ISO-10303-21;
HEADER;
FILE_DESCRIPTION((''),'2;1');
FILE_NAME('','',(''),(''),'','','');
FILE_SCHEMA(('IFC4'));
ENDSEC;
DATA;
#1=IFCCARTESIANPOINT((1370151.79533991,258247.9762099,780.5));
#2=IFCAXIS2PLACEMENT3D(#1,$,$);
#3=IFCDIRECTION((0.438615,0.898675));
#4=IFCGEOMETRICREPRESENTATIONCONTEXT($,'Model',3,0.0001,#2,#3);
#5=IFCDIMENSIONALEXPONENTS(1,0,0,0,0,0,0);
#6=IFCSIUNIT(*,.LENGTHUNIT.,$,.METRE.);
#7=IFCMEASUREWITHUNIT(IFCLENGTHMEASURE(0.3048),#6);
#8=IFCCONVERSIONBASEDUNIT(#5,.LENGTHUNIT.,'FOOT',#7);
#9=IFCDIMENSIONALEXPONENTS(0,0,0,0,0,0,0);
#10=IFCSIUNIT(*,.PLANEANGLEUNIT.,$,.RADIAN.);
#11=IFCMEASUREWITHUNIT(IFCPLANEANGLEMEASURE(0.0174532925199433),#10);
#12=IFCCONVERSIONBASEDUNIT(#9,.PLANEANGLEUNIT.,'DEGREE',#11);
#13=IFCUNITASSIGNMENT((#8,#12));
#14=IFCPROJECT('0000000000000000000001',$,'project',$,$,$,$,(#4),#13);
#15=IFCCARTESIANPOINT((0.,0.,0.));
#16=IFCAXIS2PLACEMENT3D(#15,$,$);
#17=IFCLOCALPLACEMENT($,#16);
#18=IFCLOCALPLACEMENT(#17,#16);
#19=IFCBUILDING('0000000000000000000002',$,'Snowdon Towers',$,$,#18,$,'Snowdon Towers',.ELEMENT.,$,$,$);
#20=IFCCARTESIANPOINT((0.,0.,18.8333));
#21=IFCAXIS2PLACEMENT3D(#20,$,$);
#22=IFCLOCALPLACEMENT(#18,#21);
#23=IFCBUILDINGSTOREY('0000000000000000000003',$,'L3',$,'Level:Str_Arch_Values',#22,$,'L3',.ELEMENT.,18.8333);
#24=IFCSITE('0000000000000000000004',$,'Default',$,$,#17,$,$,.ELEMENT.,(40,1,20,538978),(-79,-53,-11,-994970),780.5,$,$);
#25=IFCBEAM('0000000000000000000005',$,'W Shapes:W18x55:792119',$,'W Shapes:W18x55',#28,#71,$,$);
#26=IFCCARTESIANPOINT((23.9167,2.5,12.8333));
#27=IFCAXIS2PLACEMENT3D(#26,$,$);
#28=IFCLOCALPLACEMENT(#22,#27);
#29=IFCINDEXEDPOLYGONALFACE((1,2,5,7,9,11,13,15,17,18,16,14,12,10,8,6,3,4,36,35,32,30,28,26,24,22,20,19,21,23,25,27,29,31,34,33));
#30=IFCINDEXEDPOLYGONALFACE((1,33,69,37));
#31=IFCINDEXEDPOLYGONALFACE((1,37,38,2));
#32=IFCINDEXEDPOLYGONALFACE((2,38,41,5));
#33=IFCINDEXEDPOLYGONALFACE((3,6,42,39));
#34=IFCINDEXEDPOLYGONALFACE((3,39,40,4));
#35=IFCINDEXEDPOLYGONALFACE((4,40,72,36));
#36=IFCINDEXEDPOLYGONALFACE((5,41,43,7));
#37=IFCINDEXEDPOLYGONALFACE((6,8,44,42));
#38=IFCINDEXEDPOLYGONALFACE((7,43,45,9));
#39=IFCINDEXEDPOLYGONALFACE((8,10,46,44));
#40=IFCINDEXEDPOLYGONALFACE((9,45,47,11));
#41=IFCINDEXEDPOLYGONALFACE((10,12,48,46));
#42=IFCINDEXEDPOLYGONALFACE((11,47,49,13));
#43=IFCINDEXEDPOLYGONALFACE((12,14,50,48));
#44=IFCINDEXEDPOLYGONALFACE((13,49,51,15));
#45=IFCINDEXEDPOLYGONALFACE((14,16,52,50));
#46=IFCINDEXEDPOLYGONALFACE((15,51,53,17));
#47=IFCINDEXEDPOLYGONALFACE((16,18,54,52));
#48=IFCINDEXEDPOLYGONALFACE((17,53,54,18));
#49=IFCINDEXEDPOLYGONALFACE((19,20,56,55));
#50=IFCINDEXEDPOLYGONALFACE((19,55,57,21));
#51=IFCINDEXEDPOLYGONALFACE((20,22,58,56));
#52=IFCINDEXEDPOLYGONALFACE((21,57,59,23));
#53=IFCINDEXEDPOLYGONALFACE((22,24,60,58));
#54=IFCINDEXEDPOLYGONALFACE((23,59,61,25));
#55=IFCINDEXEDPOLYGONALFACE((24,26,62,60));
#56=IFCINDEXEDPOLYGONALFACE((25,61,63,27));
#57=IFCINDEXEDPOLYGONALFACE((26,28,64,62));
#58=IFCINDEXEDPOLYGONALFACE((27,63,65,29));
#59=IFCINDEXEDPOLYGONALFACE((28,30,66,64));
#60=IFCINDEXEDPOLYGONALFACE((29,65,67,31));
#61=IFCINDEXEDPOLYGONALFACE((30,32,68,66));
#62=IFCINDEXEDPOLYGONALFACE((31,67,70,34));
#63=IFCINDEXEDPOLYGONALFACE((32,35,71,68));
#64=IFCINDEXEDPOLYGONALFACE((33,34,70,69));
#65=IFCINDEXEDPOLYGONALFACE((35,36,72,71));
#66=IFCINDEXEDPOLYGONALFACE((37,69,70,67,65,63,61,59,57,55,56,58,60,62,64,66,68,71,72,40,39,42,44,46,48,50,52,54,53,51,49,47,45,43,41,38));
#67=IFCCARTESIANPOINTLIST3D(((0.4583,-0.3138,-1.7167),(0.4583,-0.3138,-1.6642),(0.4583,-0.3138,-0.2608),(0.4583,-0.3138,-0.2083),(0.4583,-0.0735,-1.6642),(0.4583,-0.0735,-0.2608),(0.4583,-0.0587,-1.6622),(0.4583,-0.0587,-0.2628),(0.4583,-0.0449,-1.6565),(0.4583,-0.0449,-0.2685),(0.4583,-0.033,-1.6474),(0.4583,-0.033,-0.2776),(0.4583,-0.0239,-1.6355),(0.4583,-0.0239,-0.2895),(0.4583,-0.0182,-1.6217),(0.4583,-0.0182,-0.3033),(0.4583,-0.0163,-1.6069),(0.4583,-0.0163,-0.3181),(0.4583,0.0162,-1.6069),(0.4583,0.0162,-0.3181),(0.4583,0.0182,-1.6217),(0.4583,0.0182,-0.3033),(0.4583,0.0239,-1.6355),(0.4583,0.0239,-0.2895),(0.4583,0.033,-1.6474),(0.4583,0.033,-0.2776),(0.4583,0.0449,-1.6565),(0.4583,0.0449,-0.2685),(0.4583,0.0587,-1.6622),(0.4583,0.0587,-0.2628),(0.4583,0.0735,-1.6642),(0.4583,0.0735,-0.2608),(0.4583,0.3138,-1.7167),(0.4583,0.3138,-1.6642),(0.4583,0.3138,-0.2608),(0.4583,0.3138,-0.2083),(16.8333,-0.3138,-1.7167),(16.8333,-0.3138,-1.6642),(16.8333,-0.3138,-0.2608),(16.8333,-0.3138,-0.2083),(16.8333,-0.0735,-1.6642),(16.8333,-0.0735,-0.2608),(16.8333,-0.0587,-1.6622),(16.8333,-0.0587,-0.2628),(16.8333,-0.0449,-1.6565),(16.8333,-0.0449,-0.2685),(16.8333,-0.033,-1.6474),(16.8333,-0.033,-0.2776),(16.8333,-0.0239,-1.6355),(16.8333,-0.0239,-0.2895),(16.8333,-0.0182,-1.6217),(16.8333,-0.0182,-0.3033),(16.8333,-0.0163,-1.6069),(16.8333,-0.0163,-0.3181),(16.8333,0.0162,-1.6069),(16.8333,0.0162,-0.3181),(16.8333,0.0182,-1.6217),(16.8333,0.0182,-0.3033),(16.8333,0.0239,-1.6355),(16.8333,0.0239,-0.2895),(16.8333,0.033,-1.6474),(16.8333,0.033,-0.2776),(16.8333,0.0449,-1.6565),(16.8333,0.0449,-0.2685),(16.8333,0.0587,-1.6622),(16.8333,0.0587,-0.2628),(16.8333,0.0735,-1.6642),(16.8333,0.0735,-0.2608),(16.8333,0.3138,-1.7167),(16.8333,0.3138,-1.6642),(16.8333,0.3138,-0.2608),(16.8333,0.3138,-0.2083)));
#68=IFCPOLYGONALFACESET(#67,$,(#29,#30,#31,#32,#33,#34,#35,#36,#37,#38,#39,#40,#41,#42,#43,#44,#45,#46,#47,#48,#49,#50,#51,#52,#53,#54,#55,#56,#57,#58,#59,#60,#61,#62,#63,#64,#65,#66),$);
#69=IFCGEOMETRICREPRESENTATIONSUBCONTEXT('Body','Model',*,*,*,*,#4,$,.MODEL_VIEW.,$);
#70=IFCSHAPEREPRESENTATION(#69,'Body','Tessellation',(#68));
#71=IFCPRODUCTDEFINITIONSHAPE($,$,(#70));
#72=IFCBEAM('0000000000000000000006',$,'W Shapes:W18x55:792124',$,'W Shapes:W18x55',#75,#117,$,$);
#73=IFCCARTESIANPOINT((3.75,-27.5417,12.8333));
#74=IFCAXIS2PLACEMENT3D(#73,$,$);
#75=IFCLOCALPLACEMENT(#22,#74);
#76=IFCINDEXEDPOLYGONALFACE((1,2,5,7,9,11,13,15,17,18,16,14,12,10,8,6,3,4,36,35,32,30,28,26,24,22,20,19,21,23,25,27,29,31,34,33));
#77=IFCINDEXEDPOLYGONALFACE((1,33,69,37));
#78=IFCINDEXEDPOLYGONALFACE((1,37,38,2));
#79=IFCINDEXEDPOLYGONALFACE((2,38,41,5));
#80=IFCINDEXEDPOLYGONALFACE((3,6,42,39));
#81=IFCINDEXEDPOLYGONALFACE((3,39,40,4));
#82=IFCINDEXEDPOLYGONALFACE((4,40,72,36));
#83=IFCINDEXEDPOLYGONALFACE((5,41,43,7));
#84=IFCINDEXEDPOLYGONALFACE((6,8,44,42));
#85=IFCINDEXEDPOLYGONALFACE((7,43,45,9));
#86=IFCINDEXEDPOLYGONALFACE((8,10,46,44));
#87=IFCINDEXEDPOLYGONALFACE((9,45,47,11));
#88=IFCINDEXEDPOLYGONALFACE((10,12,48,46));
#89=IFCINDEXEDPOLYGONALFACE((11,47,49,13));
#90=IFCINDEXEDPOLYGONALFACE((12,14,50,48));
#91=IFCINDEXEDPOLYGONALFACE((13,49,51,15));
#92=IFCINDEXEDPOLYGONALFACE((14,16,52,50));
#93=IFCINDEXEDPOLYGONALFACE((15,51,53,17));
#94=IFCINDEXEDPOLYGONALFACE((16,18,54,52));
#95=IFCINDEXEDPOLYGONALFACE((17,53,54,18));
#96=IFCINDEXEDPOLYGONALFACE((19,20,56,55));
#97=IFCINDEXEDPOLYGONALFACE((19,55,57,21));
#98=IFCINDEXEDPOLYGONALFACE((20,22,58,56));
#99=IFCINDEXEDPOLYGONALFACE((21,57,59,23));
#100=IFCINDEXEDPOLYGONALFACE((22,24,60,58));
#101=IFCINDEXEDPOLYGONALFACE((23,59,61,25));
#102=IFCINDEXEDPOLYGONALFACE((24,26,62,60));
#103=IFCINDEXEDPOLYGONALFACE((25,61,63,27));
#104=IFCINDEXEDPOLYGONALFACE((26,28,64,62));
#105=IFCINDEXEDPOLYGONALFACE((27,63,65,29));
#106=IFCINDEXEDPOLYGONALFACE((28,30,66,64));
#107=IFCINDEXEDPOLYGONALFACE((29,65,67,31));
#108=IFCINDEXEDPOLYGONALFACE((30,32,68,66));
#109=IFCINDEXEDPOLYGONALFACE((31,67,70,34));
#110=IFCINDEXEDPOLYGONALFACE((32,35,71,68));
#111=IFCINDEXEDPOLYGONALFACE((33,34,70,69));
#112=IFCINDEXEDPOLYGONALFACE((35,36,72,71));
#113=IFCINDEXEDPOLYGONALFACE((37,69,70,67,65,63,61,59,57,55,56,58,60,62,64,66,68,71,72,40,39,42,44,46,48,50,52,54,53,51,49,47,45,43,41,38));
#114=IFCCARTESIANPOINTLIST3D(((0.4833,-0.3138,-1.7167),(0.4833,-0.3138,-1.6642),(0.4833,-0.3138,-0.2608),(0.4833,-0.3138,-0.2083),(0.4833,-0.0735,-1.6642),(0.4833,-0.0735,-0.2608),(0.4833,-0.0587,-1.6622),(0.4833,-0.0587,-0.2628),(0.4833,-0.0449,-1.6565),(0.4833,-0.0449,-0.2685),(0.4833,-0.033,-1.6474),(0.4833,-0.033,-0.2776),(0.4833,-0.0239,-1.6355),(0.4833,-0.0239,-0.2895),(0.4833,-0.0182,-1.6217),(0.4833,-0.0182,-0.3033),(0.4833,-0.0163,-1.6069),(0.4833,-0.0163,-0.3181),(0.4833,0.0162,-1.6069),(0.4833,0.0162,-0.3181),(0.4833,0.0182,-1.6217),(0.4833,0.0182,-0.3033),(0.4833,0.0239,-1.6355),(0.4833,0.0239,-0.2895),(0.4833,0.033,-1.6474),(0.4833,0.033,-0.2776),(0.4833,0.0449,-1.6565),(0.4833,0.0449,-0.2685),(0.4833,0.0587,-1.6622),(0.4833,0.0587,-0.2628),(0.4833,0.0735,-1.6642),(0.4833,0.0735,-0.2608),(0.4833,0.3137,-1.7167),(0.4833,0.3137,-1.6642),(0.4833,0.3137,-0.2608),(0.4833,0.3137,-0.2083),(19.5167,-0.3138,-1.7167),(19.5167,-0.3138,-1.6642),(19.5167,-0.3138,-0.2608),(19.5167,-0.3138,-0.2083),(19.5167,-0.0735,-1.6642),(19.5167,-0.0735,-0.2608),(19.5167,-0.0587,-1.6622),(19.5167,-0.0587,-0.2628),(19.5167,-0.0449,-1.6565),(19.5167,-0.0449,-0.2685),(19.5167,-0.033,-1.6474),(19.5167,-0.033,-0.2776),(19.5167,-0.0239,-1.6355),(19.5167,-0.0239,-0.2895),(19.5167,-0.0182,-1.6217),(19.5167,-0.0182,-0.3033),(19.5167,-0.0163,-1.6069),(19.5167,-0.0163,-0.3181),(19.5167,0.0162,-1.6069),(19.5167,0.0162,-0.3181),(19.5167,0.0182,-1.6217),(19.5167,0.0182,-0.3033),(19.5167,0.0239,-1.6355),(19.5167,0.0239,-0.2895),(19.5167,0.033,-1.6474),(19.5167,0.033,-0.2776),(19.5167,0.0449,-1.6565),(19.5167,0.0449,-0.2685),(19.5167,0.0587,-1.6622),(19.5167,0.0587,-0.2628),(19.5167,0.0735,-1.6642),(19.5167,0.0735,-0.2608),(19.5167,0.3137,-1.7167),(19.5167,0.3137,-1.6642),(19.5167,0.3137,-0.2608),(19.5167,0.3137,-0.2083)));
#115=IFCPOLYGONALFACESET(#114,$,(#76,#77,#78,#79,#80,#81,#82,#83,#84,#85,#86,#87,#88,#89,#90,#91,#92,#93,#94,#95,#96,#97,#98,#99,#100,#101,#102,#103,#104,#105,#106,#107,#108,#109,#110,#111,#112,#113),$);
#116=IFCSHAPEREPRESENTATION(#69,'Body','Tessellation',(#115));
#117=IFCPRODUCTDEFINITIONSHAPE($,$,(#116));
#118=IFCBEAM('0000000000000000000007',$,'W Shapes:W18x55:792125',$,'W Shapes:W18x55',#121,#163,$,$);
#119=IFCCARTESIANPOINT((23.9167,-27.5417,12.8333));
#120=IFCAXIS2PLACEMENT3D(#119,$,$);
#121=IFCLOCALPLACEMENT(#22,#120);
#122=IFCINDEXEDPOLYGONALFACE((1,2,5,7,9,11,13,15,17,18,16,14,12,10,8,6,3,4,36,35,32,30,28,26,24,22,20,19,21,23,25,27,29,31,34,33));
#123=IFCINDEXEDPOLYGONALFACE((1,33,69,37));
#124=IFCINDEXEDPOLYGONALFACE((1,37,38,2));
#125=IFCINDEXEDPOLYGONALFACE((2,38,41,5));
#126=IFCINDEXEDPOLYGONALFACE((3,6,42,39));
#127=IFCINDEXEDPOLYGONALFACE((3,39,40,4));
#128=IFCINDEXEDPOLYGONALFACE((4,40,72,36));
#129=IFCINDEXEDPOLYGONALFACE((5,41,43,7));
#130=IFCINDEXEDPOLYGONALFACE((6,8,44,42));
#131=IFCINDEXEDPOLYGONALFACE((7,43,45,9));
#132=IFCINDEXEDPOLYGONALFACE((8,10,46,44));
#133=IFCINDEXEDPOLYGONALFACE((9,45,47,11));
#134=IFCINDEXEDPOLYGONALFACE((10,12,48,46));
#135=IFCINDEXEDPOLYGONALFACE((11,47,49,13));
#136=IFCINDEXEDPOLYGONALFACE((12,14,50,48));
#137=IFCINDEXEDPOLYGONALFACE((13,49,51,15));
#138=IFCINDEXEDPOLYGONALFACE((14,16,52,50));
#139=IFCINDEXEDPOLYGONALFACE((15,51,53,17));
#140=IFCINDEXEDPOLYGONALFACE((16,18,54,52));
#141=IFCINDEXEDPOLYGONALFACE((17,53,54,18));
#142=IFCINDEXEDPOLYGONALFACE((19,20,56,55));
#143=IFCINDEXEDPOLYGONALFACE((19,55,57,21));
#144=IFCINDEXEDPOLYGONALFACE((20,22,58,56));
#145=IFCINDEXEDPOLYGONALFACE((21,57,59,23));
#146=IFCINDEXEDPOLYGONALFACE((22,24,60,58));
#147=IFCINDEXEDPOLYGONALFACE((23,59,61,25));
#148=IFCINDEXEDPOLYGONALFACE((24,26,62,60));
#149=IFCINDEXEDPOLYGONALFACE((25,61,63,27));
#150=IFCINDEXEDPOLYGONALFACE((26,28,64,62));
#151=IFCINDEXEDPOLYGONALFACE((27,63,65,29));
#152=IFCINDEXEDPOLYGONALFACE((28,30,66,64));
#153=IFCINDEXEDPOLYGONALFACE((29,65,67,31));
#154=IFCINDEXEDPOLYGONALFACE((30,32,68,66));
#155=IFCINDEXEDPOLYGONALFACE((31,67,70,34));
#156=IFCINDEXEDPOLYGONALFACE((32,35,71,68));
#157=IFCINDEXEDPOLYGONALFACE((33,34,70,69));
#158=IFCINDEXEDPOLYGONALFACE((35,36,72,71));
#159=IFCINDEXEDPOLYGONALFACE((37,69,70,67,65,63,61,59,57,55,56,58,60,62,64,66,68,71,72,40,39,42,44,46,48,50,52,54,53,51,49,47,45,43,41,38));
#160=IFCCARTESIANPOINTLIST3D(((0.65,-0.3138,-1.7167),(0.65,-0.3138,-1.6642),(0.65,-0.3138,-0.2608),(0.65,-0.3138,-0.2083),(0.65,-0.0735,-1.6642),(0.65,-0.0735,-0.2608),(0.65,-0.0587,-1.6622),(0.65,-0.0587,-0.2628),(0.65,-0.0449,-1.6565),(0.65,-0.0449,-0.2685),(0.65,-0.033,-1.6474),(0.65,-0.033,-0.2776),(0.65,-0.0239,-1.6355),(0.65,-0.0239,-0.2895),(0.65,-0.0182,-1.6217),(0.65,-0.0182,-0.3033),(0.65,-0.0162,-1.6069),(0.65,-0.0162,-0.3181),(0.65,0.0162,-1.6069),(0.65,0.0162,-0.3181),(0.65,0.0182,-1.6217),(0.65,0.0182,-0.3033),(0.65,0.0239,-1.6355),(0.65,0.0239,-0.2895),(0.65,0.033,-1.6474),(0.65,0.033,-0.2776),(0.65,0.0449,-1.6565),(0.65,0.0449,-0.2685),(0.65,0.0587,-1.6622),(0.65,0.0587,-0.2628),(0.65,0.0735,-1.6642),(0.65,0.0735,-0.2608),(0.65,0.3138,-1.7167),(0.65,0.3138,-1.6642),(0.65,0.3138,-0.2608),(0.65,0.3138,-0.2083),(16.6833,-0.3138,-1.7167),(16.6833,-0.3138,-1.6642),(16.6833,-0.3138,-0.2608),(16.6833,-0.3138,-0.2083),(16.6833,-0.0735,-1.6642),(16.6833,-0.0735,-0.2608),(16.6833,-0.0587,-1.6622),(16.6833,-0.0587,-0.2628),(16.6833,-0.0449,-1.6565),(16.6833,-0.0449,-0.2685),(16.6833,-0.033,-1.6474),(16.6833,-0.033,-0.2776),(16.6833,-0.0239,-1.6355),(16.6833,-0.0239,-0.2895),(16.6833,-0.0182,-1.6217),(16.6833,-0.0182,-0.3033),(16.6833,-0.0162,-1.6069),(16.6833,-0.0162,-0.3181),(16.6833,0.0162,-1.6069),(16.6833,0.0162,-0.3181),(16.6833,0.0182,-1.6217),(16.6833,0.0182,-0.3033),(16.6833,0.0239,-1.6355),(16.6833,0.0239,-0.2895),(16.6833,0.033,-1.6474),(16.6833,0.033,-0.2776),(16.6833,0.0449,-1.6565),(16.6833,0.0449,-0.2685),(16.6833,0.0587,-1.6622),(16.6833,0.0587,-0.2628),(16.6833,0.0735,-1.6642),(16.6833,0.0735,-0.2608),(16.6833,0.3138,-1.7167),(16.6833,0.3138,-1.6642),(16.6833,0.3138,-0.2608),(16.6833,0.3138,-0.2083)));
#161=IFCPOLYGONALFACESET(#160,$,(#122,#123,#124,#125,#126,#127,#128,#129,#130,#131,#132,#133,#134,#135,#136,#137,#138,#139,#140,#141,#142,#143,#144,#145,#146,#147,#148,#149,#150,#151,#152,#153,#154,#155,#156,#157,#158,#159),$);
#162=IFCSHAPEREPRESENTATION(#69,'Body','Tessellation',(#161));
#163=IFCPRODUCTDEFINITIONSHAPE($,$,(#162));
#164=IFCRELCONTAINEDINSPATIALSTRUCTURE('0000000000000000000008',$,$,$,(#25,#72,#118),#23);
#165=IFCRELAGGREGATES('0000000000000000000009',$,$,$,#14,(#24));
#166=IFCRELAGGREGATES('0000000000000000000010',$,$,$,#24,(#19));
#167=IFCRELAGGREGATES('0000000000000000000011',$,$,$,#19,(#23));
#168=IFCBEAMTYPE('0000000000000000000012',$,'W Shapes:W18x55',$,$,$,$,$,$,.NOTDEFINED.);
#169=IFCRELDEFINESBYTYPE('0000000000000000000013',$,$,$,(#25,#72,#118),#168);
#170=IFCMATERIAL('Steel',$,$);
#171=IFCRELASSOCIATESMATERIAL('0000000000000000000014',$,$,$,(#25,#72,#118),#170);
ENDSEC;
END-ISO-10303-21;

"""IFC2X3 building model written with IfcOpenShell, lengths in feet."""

from ifc_helpers import new_model, entity, si_unit, converted_unit, direction, frame, frame_2d, origin, place, context, subcontext, project, spatial, i_section, extrude, material, type_object, element, save


model = new_model("IFC2X3")

# Units and contexts
model_context = context("Model", 3, precision=0.0001, world=frame((1370151.79533991, 258247.9762099, 780.5)), true_north=direction((0.438615, 0.898675)))
body_context = subcontext(model_context, "Body", "Model", "MODEL_VIEW")
ifc_project = project(units=[converted_unit("LENGTHUNIT", "FOOT", entity("IfcLengthMeasure", 0.3048), si_unit("LENGTHUNIT", "METRE"), dimensions=[1, 0, 0, 0, 0, 0, 0]), converted_unit("PLANEANGLEUNIT", "DEGREE", entity("IfcPlaneAngleMeasure", 0.0174532925199433), si_unit("PLANEANGLEUNIT", "RADIAN"), dimensions=[0, 0, 0, 0, 0, 0, 0])], contexts=[model_context])

# Site, building, storey
site_placement = place(None, origin())
site = spatial("IfcSite", under=ifc_project, at=site_placement, Name="Default", CompositionType="ELEMENT", RefLatitude=(40, 1, 20, 538978), RefLongitude=(-79, -53, -11, -994970), RefElevation=780.5)
building_placement = place(site_placement, origin())
building = spatial("IfcBuilding", under=site, at=building_placement, Name="Snowdon Towers", LongName="Snowdon Towers", CompositionType="ELEMENT")
storey_placement = place(building_placement, frame((0.0, 0.0, 18.8333)))
storey = spatial("IfcBuildingStorey", under=building, at=storey_placement, Name="L3", ObjectType="Level:Str_Arch_Values", LongName="L3", CompositionType="ELEMENT", Elevation=18.8333)

# Beams
ifc_material = material(Name="Steel")
beam_type_1 = type_object("IfcBeamType", Name="W Shapes:W18x55", PredefinedType="NOTDEFINED")
beam_1_placement = place(storey_placement, frame((23.9167, 2.5, 12.8333)))
element("IfcBeam", 1, at=beam_1_placement, inside=storey, type_object=beam_type_1, material=ifc_material, Name="W Shapes:W18x55:792119", ObjectType="W Shapes:W18x55", context=body_context, shape_type="SweptSolid", body=[
    extrude(i_section(OverallWidth=0.6275, OverallDepth=1.5083, WebThickness=0.0325, FlangeThickness=0.0525, FilletRadius=0.0573, at=frame_2d((0.0, 0.0), x_axis=(0.0, 1.0))), frame((0.4583, 0.0, -0.9625), z_axis=(1.0, 0.0, 0.0), x_axis=(0.0, 0.0, -1.0)), (0.0, 0.0, 1.0), 16.375),
])
beam_2_placement = place(storey_placement, frame((3.75, -27.5417, 12.8333)))
element("IfcBeam", 2, at=beam_2_placement, inside=storey, type_object=beam_type_1, material=ifc_material, Name="W Shapes:W18x55:792124", ObjectType="W Shapes:W18x55", context=body_context, shape_type="SweptSolid", body=[
    extrude(i_section(OverallWidth=0.6275, OverallDepth=1.5083, WebThickness=0.0325, FlangeThickness=0.0525, FilletRadius=0.0573, at=frame_2d((0.0, 0.0), x_axis=(0.0, 1.0))), frame((0.4833, 0.0, -0.9625), z_axis=(1.0, 0.0, 0.0), x_axis=(0.0, 0.0, -1.0)), (0.0, 0.0, 1.0), 19.0333),
])
beam_3_placement = place(storey_placement, frame((23.9167, -27.5417, 12.8333)))
element("IfcBeam", 3, at=beam_3_placement, inside=storey, type_object=beam_type_1, material=ifc_material, Name="W Shapes:W18x55:792125", ObjectType="W Shapes:W18x55", context=body_context, shape_type="SweptSolid", body=[
    extrude(i_section(OverallWidth=0.6275, OverallDepth=1.5083, WebThickness=0.0325, FlangeThickness=0.0525, FilletRadius=0.0573, at=frame_2d((0.0, 0.0), x_axis=(0.0, 1.0))), frame((0.65, 0.0, -0.9625), z_axis=(1.0, 0.0, 0.0), x_axis=(0.0, 0.0, -1.0)), (0.0, 0.0, 1.0), 16.0333),
])

save(model, "model.ifc")
